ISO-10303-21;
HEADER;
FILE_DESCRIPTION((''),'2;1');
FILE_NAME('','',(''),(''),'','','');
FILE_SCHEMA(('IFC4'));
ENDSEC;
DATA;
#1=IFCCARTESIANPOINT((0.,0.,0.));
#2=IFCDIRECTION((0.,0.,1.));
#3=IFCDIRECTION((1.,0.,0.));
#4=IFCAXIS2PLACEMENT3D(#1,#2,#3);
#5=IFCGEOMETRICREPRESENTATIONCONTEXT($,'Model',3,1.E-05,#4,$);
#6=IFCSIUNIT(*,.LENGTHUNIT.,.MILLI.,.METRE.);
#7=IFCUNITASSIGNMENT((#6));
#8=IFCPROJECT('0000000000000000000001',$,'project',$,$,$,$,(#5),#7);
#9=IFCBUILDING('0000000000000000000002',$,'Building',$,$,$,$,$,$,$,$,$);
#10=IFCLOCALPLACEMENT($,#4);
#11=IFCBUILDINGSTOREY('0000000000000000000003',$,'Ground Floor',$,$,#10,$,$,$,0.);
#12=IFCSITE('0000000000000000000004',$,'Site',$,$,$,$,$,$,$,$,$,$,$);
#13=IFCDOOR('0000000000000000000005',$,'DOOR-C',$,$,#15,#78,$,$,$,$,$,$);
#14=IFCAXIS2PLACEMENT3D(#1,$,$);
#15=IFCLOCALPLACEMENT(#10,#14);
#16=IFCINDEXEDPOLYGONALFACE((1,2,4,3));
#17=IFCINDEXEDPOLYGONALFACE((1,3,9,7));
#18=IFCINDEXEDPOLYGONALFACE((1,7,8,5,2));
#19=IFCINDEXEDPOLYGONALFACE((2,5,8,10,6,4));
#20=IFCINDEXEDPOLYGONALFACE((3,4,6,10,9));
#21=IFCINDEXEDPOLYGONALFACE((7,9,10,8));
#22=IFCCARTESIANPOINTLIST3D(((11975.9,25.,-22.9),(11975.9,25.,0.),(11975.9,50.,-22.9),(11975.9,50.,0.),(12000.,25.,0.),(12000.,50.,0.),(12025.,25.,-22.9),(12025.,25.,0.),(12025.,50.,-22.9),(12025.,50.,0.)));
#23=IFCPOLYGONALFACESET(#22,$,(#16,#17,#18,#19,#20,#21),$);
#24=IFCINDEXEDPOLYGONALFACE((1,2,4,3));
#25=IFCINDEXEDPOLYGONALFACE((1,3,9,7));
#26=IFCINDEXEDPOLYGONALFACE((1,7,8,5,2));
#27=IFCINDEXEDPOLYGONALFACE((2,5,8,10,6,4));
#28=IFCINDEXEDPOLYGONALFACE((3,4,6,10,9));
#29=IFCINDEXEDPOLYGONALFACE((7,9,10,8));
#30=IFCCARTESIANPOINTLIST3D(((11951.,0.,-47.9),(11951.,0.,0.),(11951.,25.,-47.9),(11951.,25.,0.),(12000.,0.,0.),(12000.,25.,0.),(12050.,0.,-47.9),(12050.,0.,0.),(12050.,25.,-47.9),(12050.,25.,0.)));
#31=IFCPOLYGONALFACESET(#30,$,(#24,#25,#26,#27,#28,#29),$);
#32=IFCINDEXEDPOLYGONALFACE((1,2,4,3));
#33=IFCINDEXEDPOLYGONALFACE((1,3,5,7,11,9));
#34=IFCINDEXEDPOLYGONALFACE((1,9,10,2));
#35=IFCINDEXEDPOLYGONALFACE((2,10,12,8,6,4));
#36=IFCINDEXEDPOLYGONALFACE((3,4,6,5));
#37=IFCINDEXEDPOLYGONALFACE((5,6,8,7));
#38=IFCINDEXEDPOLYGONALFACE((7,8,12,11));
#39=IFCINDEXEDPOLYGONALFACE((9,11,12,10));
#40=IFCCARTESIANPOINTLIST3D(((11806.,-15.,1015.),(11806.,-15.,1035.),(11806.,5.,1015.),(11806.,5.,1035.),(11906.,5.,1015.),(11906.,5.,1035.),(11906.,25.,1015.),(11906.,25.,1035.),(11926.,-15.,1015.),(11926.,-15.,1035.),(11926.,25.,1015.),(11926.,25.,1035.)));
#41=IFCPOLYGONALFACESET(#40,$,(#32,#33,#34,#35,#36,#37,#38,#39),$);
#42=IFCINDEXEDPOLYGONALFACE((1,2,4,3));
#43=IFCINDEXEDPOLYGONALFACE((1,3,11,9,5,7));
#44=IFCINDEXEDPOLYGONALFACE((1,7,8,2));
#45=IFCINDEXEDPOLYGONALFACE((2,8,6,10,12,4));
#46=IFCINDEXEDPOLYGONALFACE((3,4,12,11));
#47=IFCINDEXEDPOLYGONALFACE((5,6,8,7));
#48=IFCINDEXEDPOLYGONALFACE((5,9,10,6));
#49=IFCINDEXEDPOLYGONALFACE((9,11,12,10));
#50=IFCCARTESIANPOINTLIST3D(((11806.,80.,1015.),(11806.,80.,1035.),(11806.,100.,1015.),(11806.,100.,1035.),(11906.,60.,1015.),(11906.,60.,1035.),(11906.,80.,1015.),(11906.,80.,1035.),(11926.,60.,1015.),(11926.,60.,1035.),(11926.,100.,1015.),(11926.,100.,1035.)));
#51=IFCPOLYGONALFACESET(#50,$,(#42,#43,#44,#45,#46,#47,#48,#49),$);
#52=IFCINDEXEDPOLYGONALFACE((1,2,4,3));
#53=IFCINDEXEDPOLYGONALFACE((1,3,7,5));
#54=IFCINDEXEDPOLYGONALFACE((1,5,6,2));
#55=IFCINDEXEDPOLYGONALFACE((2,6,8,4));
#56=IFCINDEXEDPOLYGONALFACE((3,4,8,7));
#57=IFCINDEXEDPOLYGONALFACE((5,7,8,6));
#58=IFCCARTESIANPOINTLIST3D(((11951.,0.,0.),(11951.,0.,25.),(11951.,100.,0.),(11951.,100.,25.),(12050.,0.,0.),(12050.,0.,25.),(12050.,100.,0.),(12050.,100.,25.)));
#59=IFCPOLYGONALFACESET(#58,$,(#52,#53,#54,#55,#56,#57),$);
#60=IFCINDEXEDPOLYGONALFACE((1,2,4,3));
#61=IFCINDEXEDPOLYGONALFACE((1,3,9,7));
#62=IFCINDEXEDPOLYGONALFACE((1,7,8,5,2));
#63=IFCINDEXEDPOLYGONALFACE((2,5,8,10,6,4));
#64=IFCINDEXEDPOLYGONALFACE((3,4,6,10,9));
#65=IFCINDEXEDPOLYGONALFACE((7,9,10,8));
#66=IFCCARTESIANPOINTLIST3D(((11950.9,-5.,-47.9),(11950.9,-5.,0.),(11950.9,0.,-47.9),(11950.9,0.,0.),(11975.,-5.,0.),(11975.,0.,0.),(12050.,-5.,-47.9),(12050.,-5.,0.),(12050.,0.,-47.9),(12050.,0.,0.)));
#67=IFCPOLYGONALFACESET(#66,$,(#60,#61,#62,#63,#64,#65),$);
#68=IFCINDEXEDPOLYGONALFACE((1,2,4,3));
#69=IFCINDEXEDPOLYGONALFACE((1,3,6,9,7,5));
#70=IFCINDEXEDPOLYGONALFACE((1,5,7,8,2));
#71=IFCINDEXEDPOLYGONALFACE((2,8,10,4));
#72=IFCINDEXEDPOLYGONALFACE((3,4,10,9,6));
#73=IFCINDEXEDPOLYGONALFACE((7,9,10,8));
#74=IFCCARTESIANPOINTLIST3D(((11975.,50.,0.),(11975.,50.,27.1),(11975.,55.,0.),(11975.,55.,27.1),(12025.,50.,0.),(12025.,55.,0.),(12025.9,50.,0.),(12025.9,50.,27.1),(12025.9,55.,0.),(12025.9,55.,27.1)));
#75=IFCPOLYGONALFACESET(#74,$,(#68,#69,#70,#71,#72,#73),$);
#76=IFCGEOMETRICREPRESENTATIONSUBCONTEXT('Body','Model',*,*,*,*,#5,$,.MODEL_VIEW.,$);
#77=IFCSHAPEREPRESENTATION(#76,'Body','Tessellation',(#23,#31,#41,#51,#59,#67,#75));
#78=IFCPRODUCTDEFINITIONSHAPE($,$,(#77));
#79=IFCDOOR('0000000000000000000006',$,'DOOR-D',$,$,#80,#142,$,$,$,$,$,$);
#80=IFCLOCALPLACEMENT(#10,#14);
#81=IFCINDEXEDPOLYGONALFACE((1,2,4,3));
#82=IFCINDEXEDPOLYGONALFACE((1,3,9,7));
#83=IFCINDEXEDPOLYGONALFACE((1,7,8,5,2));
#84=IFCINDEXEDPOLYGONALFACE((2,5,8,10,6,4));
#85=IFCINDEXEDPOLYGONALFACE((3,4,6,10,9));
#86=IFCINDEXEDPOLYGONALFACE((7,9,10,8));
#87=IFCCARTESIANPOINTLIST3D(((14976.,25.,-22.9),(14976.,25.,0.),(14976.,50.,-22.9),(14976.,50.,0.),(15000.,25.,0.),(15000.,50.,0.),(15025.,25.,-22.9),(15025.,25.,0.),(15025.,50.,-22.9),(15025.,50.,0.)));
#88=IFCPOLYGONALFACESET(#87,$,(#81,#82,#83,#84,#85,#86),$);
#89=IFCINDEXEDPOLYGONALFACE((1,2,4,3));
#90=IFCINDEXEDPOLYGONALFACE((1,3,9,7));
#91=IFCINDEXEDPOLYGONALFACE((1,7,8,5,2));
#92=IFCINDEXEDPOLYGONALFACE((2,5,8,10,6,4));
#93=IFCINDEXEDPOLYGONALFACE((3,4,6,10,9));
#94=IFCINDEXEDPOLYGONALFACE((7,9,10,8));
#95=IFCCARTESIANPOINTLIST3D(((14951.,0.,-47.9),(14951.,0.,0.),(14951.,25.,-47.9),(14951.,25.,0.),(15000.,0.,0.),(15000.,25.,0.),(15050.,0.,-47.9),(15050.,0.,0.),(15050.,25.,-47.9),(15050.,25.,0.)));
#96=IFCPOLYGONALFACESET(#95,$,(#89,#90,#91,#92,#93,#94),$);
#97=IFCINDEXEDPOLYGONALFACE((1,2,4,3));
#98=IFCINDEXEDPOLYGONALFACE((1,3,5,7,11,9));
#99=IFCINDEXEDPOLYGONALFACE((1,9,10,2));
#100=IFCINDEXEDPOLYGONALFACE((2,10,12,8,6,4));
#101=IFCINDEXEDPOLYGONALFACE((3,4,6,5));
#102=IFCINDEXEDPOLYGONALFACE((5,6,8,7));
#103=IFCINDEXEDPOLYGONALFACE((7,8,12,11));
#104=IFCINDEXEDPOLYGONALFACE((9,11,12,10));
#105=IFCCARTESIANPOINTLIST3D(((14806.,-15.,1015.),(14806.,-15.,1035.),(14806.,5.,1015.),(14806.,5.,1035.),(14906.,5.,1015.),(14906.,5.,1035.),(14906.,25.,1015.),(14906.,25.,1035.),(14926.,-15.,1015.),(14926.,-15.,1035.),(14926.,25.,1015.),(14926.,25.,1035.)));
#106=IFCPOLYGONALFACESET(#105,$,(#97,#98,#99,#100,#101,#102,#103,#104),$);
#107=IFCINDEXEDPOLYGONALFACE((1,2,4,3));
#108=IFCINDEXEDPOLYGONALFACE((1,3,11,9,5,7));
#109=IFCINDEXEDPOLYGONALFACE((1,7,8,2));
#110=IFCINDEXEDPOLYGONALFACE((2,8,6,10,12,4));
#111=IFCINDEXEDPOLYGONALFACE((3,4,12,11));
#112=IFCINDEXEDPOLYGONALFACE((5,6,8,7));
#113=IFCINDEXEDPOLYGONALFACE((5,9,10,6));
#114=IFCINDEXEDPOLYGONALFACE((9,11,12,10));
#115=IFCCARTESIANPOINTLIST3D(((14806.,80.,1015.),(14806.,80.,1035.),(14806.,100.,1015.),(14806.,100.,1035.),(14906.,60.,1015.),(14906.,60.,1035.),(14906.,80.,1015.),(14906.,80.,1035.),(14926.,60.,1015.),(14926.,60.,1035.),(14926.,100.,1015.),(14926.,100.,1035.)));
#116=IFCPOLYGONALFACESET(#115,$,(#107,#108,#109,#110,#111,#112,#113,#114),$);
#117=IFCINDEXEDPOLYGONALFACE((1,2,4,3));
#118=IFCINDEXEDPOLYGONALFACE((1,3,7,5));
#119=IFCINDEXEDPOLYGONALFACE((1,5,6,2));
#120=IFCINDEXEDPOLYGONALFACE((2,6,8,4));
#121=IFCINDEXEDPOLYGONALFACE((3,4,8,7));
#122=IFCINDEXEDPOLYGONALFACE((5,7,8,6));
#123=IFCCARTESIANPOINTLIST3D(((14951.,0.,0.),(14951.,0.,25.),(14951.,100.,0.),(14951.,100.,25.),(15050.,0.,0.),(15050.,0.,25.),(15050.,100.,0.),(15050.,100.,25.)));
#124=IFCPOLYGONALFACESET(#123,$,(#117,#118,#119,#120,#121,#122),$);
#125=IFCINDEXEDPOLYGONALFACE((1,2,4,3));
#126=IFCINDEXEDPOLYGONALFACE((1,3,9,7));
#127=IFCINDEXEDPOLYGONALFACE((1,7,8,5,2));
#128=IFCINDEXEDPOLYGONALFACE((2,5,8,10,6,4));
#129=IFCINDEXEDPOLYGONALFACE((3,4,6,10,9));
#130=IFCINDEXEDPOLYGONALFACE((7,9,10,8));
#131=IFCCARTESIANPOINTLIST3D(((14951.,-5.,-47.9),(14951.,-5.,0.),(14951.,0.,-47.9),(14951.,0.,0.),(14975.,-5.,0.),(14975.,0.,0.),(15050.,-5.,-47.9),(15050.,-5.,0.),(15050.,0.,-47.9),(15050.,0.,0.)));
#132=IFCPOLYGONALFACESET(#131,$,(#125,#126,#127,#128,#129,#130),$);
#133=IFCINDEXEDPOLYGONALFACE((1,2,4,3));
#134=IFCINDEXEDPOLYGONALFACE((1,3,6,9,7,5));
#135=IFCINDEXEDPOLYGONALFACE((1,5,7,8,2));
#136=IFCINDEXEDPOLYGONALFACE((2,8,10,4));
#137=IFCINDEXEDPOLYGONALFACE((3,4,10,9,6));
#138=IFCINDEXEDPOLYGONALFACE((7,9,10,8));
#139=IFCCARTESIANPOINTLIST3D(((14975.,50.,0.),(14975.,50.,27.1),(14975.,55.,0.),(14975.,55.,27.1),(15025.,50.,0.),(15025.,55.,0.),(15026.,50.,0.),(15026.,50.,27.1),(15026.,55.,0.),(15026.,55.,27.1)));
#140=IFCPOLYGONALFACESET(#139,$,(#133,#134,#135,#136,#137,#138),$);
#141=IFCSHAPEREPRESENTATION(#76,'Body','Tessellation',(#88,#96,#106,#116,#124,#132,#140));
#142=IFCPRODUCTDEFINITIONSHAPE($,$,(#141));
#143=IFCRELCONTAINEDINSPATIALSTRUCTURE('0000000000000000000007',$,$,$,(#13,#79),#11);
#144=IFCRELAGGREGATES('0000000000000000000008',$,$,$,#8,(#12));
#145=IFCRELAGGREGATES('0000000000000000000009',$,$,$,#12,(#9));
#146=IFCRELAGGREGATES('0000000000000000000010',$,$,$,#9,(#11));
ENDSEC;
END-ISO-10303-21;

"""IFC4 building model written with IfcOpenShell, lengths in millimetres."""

from ifc_helpers import new_model, si_unit, frame, origin_with_axes, place, context, subcontext, project, spatial, line, indexed_curve, outline, extrude, element, save


model = new_model("IFC4")

# Units and contexts
model_context = context("Model", 3, precision=1e-05, world=origin_with_axes())
body_context = subcontext(model_context, "Body", "Model", "MODEL_VIEW")
ifc_project = project(units=[si_unit("LENGTHUNIT", "METRE", prefix="MILLI")], contexts=[model_context])

# Site, building, storey
site = spatial("IfcSite", under=ifc_project, Name="Site")
building = spatial("IfcBuilding", under=site, Name="Building")
storey_placement = place(None, origin_with_axes())
storey = spatial("IfcBuildingStorey", under=building, at=storey_placement, Name="Ground Floor", Elevation=0.0)

# Doors
door_1_placement = place(storey_placement, frame((12000.0, 0.0, 0.0), z_axis=(0.0, 0.0, 1.0), x_axis=(1.0, 0.0, 0.0)))
element("IfcDoor", 1, at=door_1_placement, inside=storey, Name="DOOR-C", context=body_context, shape_type="SweptSolid", body=[
    extrude(outline(indexed_curve([(0.0, 0.0), (0.0, 2.1), (0.9, 2.1), (0.9, 0.0), (-24.1, 0.0), (-24.1, -22.9), (25.0, -22.9), (25.0, 0.0)], segments=[line(1, 2, 3, 4, 5, 6, 7, 8, 1)])), frame((0.0, 25.0, 0.0), z_axis=(0.0, -1.0, 0.0), x_axis=(1.0, 0.0, 0.0)), (0.0, 0.0, -1.0), 25.0),
    extrude(outline(indexed_curve([(0.0, 0.0), (0.0, 2.1), (0.9, 2.1), (0.9, 0.0), (-49.0, 0.0), (-49.0, -47.9), (50.0, -47.9), (50.0, 0.0)], segments=[line(1, 2, 3, 4, 5, 6, 7, 8, 1)])), frame((0.0, 0.0, 0.0), z_axis=(0.0, -1.0, 0.0), x_axis=(1.0, 0.0, 0.0)), (0.0, 0.0, -1.0), 25.0),
    extrude(outline(indexed_curve([(0.0, 0.0), (-49.0, 0.0), (-49.0, 35.0), (0.0, 35.0)], segments=[line(1, 2, 3, 4, 1)])), frame((25.0, 25.0, 25.0), z_axis=(0.0, 0.0, 1.0), x_axis=(1.0, 0.0, 0.0)), (0.0, 0.0, 1.0), -47.9),
    extrude(outline(indexed_curve([(0.0, 0.0), (0.0, -40.0), (-120.0, -40.0), (-120.0, -20.0), (-20.0, -20.0), (-20.0, 0.0)], segments=[line(1, 2, 3, 4, 5, 6, 1)])), frame((-74.1, 25.0, 1015.0), z_axis=(0.0, 0.0, 1.0), x_axis=(1.0, 0.0, 0.0)), (0.0, 0.0, 1.0), 20.0),
    extrude(outline(indexed_curve([(0.0, 0.0), (0.0, 40.0), (-120.0, 40.0), (-120.0, 20.0), (-20.0, 20.0), (-20.0, 0.0)], segments=[line(1, 2, 3, 4, 5, 6, 1)])), frame((-74.1, 60.0, 1015.0), z_axis=(0.0, 0.0, 1.0), x_axis=(1.0, 0.0, 0.0)), (0.0, 0.0, 1.0), 20.0),
    extrude(outline(indexed_curve([(0.0, 0.0), (-99.0, 0.0), (-99.0, 100.0), (0.0, 100.0)], segments=[line(1, 2, 3, 4, 1)])), frame((50.0, 0.0, 0.0), z_axis=(0.0, 0.0, 1.0), x_axis=(1.0, 0.0, 0.0)), (0.0, 0.0, 1.0), 25.0),
    extrude(outline(indexed_curve([(0.0, 0.0), (0.0, 27.1), (51.0, 27.1), (51.0, 0.0), (-24.0, 0.0), (-24.0, -47.9), (75.0, -47.9), (75.0, 0.0)], segments=[line(1, 2, 3, 4, 5, 6, 7, 8, 1)])), frame((-25.0, -5.0, 0.0), z_axis=(0.0, -1.0, 0.0), x_axis=(1.0, 0.0, 0.0)), (0.0, 0.0, -1.0), 5.0),
    extrude(outline(indexed_curve([(0.0, 0.0), (0.0, 27.1), (51.0, 27.1), (51.0, 0.0), (1.0, 0.0), (1.0, -22.9), (50.0, -22.9), (50.0, 0.0)], segments=[line(1, 2, 3, 4, 5, 6, 7, 8, 1)])), frame((-25.0, 50.0, 0.0), z_axis=(0.0, -1.0, 0.0), x_axis=(1.0, 0.0, 0.0)), (0.0, 0.0, -1.0), 5.0),
])
door_2_placement = place(storey_placement, frame((15000.0, 0.0, 0.0), z_axis=(0.0, 0.0, 1.0), x_axis=(1.0, 0.0, 0.0)))
element("IfcDoor", 2, at=door_2_placement, inside=storey, Name="DOOR-D", context=body_context, shape_type="SweptSolid", body=[
    extrude(outline(indexed_curve([(0.0, 0.0), (0.0, 2.1), (1.0, 2.1), (1.0, 0.0), (-24.0, 0.0), (-24.0, -22.9), (25.0, -22.9), (25.0, 0.0)], segments=[line(1, 2, 3, 4, 5, 6, 7, 8, 1)])), frame((0.0, 25.0, 0.0), z_axis=(0.0, -1.0, 0.0), x_axis=(1.0, 0.0, 0.0)), (0.0, 0.0, -1.0), 25.0),
    extrude(outline(indexed_curve([(0.0, 0.0), (0.0, 2.1), (1.0, 2.1), (1.0, 0.0), (-49.0, 0.0), (-49.0, -47.9), (50.0, -47.9), (50.0, 0.0)], segments=[line(1, 2, 3, 4, 5, 6, 7, 8, 1)])), frame((0.0, 0.0, 0.0), z_axis=(0.0, -1.0, 0.0), x_axis=(1.0, 0.0, 0.0)), (0.0, 0.0, -1.0), 25.0),
    extrude(outline(indexed_curve([(0.0, 0.0), (-49.0, 0.0), (-49.0, 35.0), (0.0, 35.0)], segments=[line(1, 2, 3, 4, 1)])), frame((25.0, 25.0, 25.0), z_axis=(0.0, 0.0, 1.0), x_axis=(1.0, 0.0, 0.0)), (0.0, 0.0, 1.0), -47.9),
    extrude(outline(indexed_curve([(0.0, 0.0), (0.0, -40.0), (-120.0, -40.0), (-120.0, -20.0), (-20.0, -20.0), (-20.0, 0.0)], segments=[line(1, 2, 3, 4, 5, 6, 1)])), frame((-74.0, 25.0, 1015.0), z_axis=(0.0, 0.0, 1.0), x_axis=(1.0, 0.0, 0.0)), (0.0, 0.0, 1.0), 20.0),
    extrude(outline(indexed_curve([(0.0, 0.0), (0.0, 40.0), (-120.0, 40.0), (-120.0, 20.0), (-20.0, 20.0), (-20.0, 0.0)], segments=[line(1, 2, 3, 4, 5, 6, 1)])), frame((-74.0, 60.0, 1015.0), z_axis=(0.0, 0.0, 1.0), x_axis=(1.0, 0.0, 0.0)), (0.0, 0.0, 1.0), 20.0),
    extrude(outline(indexed_curve([(0.0, 0.0), (-99.0, 0.0), (-99.0, 100.0), (0.0, 100.0)], segments=[line(1, 2, 3, 4, 1)])), frame((50.0, 0.0, 0.0), z_axis=(0.0, 0.0, 1.0), x_axis=(1.0, 0.0, 0.0)), (0.0, 0.0, 1.0), 25.0),
    extrude(outline(indexed_curve([(0.0, 0.0), (0.0, 27.1), (51.0, 27.1), (51.0, 0.0), (-24.0, 0.0), (-24.0, -47.9), (75.0, -47.9), (75.0, 0.0)], segments=[line(1, 2, 3, 4, 5, 6, 7, 8, 1)])), frame((-25.0, -5.0, 0.0), z_axis=(0.0, -1.0, 0.0), x_axis=(1.0, 0.0, 0.0)), (0.0, 0.0, -1.0), 5.0),
    extrude(outline(indexed_curve([(0.0, 0.0), (0.0, 27.1), (51.0, 27.1), (51.0, 0.0), (1.0, 0.0), (1.0, -22.9), (50.0, -22.9), (50.0, 0.0)], segments=[line(1, 2, 3, 4, 5, 6, 7, 8, 1)])), frame((-25.0, 50.0, 0.0), z_axis=(0.0, -1.0, 0.0), x_axis=(1.0, 0.0, 0.0)), (0.0, 0.0, -1.0), 5.0),
])

save(model, "model.ifc")
